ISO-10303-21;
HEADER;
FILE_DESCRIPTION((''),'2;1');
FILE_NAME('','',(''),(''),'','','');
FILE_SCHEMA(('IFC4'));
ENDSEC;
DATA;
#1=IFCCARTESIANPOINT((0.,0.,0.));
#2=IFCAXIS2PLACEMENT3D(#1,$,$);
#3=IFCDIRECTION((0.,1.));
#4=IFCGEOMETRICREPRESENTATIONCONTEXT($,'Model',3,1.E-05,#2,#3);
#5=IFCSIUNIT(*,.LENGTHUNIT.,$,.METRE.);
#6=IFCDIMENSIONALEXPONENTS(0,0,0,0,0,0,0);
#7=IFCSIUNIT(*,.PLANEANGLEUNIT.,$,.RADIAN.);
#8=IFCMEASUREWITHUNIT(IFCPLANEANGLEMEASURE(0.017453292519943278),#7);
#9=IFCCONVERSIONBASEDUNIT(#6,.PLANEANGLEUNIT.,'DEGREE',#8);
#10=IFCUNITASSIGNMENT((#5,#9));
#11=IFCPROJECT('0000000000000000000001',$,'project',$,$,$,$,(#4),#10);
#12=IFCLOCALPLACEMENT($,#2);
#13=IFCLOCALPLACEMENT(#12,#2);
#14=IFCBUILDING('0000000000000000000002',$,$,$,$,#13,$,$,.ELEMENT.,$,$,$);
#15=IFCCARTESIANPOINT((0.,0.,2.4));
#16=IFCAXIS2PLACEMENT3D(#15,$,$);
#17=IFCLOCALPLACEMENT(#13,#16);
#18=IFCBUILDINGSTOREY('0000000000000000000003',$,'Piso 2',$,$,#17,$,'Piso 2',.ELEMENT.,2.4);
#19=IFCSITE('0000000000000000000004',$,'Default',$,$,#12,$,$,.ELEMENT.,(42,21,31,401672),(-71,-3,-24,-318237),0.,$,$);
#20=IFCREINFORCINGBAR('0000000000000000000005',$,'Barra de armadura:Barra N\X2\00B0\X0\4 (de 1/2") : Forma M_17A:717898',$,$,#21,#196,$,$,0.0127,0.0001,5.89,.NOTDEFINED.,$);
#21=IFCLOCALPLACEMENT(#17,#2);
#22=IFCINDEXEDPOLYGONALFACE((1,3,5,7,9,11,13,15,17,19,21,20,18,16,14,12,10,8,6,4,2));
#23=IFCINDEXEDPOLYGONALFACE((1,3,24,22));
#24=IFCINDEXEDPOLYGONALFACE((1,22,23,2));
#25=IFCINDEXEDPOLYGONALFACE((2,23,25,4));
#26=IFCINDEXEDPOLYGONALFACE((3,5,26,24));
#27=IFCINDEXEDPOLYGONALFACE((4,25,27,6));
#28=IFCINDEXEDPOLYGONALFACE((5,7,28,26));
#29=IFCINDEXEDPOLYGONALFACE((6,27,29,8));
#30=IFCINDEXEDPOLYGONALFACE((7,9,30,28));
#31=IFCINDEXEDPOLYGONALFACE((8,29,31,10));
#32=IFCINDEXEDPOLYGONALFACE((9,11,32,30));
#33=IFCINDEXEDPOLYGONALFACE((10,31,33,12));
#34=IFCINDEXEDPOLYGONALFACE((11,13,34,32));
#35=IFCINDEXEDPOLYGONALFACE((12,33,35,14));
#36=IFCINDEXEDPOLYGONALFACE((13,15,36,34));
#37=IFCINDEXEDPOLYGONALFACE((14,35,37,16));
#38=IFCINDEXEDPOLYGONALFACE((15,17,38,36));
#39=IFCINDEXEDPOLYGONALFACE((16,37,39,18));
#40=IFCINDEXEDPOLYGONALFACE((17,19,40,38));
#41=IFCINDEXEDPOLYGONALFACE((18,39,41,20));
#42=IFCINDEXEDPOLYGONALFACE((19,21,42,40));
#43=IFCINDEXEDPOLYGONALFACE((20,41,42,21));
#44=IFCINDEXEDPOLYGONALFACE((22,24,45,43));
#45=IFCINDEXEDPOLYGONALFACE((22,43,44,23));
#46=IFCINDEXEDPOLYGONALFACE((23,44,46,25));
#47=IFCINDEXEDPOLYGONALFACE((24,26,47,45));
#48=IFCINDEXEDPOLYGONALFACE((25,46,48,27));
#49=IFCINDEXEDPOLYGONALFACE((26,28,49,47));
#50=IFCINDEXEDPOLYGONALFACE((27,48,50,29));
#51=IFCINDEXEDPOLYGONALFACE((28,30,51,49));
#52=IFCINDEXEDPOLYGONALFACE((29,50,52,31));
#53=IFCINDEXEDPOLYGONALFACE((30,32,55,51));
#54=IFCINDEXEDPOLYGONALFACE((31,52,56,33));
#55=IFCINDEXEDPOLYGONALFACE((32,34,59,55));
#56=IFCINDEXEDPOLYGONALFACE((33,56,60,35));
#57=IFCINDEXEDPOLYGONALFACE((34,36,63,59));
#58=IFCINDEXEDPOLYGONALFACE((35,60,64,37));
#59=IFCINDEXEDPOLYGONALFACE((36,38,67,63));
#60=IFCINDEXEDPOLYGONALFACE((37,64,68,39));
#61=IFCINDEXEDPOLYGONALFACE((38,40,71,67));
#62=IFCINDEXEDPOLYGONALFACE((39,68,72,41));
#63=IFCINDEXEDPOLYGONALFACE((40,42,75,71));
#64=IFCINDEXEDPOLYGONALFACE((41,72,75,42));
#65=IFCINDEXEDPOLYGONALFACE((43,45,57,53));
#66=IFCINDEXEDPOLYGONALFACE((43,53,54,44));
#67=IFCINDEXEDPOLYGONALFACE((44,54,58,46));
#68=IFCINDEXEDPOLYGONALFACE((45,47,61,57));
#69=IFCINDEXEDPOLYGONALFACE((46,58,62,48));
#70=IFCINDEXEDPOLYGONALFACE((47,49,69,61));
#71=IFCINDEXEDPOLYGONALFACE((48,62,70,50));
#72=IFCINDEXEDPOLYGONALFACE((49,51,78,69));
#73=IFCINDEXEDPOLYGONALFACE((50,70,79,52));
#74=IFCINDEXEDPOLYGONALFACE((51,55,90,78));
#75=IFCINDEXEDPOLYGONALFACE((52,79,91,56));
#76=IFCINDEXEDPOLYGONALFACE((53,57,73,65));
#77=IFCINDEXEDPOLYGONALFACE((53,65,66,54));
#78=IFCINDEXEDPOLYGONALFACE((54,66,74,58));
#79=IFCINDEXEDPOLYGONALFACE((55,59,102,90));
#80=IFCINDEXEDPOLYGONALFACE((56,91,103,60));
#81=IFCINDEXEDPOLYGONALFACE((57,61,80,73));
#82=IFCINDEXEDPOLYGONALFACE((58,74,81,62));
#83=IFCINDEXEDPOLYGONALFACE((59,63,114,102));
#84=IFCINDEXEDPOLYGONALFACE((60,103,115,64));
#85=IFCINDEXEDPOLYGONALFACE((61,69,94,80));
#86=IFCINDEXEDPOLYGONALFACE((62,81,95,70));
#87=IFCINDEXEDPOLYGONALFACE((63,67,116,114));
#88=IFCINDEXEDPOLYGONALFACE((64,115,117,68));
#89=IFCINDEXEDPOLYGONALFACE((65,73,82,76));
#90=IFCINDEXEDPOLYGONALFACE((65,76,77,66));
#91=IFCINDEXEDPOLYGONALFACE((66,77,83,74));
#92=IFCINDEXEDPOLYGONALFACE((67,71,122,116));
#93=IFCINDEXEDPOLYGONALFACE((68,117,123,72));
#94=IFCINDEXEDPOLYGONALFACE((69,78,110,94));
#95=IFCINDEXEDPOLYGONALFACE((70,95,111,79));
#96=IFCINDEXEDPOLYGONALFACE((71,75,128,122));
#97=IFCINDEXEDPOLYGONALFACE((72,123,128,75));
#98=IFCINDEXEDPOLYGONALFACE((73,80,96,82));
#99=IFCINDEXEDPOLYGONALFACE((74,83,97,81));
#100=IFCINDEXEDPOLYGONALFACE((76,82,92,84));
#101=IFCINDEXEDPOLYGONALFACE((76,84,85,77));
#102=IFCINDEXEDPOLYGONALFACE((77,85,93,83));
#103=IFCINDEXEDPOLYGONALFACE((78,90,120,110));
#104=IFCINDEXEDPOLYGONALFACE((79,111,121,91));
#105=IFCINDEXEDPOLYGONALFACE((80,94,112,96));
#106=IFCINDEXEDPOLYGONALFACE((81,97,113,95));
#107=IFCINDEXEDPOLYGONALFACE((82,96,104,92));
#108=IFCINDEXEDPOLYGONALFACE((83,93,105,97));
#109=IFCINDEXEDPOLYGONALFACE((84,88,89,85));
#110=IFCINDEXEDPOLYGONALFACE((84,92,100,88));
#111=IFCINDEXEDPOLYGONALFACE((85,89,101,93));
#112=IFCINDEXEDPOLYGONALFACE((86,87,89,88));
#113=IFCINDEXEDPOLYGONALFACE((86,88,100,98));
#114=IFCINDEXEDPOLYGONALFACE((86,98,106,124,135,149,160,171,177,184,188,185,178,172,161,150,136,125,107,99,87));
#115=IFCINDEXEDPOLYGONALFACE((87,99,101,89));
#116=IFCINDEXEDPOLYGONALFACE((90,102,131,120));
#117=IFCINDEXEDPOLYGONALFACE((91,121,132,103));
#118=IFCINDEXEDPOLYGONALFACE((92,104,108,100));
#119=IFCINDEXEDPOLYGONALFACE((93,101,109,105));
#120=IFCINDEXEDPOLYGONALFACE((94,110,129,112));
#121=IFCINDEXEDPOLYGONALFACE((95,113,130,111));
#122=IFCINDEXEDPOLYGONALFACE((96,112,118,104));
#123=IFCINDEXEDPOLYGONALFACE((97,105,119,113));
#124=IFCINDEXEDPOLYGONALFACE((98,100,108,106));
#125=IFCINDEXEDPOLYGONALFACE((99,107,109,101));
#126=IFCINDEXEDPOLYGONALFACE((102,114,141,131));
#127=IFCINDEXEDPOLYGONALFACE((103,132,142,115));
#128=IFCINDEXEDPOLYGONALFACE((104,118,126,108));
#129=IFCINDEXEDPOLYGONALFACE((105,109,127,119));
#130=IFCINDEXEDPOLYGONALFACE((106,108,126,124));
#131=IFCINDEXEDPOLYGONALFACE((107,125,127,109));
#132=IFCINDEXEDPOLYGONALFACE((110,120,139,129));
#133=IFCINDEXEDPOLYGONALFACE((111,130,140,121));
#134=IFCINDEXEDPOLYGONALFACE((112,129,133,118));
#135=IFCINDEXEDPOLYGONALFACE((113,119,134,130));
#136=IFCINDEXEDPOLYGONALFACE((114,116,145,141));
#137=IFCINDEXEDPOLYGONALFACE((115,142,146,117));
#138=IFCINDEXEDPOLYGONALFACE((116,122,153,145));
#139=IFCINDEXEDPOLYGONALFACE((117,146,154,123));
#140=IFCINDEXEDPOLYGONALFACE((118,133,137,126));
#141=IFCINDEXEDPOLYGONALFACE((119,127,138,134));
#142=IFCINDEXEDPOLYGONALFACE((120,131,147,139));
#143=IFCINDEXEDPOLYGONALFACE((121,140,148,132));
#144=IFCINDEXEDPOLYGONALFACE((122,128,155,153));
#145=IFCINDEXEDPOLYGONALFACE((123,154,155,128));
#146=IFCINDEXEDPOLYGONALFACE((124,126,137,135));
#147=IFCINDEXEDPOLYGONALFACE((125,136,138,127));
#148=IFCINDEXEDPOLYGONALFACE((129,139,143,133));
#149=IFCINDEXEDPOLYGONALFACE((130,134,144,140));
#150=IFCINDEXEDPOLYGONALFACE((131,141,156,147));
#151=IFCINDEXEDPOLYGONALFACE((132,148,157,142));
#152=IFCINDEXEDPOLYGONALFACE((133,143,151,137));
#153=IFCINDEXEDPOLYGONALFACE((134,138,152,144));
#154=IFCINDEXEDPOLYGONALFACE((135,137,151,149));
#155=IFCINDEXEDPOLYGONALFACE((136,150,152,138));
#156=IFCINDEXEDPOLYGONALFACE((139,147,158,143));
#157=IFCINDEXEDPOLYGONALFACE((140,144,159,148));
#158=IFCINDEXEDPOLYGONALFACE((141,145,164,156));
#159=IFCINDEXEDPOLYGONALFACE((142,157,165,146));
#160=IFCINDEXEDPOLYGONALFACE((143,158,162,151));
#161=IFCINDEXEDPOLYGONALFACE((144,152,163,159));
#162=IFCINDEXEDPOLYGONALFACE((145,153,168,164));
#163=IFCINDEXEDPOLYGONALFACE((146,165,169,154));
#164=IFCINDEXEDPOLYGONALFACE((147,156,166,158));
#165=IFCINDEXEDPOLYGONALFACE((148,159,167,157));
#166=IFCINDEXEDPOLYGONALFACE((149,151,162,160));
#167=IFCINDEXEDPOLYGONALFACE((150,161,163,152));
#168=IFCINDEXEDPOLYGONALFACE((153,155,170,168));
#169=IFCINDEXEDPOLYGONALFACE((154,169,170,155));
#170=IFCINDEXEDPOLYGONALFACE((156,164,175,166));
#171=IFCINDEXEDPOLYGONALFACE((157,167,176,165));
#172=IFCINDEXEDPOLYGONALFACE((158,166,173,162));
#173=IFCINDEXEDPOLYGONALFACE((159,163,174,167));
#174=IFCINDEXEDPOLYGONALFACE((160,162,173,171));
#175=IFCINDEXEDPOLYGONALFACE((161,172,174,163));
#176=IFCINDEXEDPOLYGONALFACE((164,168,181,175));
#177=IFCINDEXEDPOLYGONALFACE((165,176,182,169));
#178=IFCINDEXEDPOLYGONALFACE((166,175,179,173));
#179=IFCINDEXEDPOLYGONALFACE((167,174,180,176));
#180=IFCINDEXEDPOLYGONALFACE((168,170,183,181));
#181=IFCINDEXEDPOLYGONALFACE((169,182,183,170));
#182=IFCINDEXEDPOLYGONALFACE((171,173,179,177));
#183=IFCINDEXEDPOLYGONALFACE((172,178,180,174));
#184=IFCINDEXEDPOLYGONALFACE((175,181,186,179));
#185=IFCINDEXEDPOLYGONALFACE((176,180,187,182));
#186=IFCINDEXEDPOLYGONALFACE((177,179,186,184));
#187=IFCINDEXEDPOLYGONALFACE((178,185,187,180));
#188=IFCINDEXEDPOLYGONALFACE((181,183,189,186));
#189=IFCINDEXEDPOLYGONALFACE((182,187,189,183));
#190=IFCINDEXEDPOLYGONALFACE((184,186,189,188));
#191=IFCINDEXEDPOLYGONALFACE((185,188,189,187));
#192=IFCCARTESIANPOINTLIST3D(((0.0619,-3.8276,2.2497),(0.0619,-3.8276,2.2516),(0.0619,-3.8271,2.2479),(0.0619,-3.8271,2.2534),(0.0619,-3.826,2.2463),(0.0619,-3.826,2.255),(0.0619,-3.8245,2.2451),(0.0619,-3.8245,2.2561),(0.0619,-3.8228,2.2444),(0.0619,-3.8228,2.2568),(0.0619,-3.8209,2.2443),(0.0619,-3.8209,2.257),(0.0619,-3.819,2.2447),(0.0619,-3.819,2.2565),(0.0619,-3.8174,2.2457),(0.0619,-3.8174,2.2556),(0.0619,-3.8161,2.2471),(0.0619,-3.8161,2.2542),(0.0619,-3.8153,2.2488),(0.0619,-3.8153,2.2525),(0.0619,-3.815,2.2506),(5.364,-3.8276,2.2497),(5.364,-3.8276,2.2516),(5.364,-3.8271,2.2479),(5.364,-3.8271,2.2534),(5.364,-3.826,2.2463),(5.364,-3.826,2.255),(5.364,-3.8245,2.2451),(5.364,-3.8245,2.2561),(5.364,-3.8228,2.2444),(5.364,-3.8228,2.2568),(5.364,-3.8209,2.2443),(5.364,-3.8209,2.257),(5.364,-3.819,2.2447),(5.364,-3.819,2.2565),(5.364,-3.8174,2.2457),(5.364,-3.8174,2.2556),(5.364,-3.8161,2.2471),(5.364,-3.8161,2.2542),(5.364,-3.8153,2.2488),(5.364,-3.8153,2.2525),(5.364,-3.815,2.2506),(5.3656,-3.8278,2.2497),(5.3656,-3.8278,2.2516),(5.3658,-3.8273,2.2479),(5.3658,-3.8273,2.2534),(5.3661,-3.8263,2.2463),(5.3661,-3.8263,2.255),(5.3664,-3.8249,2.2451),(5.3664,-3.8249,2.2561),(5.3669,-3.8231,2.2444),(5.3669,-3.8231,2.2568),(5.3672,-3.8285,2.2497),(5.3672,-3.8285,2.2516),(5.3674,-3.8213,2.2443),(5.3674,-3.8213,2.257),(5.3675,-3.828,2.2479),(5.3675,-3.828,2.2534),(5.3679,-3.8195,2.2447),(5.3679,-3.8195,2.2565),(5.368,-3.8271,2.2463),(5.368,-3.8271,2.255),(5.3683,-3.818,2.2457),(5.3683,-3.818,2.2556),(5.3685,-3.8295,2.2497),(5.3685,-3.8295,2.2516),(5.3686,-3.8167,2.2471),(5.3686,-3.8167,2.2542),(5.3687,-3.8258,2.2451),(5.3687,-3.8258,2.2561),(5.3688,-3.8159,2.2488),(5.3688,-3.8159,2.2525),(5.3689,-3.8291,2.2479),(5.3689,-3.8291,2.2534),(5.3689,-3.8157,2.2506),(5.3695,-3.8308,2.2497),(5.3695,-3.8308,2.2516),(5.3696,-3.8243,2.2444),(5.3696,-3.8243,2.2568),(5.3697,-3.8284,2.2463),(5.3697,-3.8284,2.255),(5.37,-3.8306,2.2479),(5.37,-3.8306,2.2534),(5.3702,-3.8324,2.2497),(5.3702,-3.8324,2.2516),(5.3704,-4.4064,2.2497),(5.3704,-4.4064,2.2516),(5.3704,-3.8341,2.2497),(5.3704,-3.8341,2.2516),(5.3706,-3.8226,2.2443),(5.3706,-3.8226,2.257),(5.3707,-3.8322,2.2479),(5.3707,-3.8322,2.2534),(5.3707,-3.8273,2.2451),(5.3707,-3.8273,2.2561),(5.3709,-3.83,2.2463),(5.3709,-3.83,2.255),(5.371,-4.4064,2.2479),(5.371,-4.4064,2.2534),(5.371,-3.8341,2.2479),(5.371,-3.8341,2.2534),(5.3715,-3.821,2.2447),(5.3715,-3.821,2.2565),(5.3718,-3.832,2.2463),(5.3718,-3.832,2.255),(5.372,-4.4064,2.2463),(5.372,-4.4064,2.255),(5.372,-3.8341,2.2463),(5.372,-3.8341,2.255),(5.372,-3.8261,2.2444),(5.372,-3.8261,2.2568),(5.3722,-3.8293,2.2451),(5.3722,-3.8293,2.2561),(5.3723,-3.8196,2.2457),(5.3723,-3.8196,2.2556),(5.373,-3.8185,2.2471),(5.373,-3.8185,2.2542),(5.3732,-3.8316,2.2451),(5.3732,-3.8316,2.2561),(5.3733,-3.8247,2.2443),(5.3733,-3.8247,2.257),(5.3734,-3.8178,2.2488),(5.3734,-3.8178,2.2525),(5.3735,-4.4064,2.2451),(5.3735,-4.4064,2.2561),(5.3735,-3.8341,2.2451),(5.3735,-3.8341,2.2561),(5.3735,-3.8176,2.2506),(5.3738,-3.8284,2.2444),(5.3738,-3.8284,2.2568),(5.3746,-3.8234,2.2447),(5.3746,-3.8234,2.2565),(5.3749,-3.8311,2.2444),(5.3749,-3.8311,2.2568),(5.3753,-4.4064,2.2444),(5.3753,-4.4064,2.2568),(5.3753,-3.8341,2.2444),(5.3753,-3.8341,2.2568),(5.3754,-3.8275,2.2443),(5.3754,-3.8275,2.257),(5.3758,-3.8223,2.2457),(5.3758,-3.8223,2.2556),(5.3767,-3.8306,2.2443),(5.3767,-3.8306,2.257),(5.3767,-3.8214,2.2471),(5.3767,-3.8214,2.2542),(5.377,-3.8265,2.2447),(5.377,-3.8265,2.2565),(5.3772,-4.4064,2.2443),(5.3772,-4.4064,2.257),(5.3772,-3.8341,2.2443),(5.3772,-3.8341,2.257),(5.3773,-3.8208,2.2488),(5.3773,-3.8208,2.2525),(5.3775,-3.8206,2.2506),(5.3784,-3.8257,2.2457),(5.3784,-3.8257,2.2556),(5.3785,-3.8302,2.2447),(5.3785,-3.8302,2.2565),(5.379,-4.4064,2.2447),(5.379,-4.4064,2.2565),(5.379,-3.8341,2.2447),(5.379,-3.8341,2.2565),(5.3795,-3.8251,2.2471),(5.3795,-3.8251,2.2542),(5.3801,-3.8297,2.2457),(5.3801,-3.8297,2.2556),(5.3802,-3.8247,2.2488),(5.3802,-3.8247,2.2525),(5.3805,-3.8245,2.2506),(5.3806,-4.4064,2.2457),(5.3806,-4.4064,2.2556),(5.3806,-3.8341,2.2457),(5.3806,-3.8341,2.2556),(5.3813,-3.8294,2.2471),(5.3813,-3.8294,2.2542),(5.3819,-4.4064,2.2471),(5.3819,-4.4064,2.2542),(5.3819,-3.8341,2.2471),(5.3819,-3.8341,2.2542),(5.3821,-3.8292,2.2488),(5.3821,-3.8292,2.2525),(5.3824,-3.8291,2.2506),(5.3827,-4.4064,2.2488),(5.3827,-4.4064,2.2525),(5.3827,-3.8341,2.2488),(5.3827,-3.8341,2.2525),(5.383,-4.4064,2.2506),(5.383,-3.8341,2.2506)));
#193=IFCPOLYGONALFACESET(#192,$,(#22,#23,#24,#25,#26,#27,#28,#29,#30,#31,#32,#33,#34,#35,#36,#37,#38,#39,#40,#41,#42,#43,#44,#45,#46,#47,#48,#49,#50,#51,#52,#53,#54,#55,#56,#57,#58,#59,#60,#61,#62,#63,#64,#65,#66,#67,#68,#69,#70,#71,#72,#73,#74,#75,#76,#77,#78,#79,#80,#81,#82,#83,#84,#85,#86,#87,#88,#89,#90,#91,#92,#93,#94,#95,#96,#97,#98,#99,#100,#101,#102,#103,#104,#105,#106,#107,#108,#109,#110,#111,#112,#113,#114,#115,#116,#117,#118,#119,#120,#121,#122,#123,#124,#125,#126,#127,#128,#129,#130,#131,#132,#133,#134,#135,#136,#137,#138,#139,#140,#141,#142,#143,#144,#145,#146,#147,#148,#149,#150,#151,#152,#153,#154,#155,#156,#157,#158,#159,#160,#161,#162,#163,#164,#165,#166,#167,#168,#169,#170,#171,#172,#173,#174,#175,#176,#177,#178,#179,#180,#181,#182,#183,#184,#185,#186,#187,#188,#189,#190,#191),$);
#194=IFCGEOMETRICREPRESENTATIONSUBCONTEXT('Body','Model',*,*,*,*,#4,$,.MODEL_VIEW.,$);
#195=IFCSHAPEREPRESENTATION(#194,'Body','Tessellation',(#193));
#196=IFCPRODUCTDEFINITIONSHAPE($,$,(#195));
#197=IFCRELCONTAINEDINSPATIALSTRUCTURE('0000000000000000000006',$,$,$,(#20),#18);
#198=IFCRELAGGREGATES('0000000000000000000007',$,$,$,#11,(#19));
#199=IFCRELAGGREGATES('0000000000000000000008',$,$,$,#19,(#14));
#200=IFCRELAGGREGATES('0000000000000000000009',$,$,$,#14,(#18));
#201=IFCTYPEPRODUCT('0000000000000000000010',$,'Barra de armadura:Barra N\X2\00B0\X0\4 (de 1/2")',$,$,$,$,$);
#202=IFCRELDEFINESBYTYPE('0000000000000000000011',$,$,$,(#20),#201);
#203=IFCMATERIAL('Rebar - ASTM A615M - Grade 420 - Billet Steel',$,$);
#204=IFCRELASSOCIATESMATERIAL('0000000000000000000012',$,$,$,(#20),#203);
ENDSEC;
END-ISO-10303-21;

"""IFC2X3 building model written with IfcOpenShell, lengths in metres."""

from ifc_helpers import new_model, entity, si_unit, converted_unit, direction, frame, origin, place, context, subcontext, project, spatial, material, type_object, element, save


model = new_model("IFC2X3")

# Units and contexts
model_context = context("Model", 3, precision=1e-05, world=origin(), true_north=direction((0.0, 1.0)))
body_context = subcontext(model_context, "Body", "Model", "MODEL_VIEW")
ifc_project = project(units=[si_unit("LENGTHUNIT", "METRE"), converted_unit("PLANEANGLEUNIT", "DEGREE", entity("IfcPlaneAngleMeasure", 0.017453292519943278), si_unit("PLANEANGLEUNIT", "RADIAN"), dimensions=[0, 0, 0, 0, 0, 0, 0])], contexts=[model_context])

# Site, building, storey
site_placement = place(None, origin())
site = spatial("IfcSite", under=ifc_project, at=site_placement, Name="Default", CompositionType="ELEMENT", RefLatitude=(42, 21, 31, 401672), RefLongitude=(-71, -3, -24, -318237), RefElevation=0.0)
building_placement = place(site_placement, origin())
building = spatial("IfcBuilding", under=site, at=building_placement, CompositionType="ELEMENT")
storey_placement = place(building_placement, frame((0.0, 0.0, 2.4)))
storey = spatial("IfcBuildingStorey", under=building, at=storey_placement, Name="Piso 2", LongName="Piso 2", CompositionType="ELEMENT", Elevation=2.4)

# Reinforcing bar
ifc_material_1 = material(Name="Rebar - ASTM A615M - Grade 420 - Billet Steel")
type_product_1 = type_object("IfcTypeProduct", Name="Barra de armadura:Barra N°4 (de 1/2\")")
reinforcing_bar_1_placement = place(storey_placement, origin())
element("IfcReinforcingBar", 1, at=reinforcing_bar_1_placement, inside=storey, type_object=type_product_1, material=ifc_material_1, Name="Barra de armadura:Barra N°4 (de 1/2\") : Forma M_17A:717898", BarLength=5.89, BarRole="NOTDEFINED", CrossSectionArea=0.0001, NominalDiameter=0.0127, context=body_context, shape_type="AdvancedSweptSolid", body=[
    entity("IfcSweptDiskSolid", entity("IfcCompositeCurve", [entity("IfcCompositeCurveSegment", "CONTINUOUS", True, entity("IfcPolyline", [entity("IfcCartesianPoint", [0.0619, -3.8214, 2.2506]), entity("IfcCartesianPoint", [5.364, -3.8214, 2.2506])])), entity("IfcCompositeCurveSegment", "CONTINUOUS", True, entity("IfcTrimmedCurve", entity("IfcCircle", entity("IfcAxis2Placement3D", entity("IfcCartesianPoint", [5.364, -3.8341, 2.2506]), entity("IfcDirection", [0.0, 0.0, -1.0]), entity("IfcDirection", [1.0, 0.0, 0.0])), 0.0127), [entity("IfcParameterValue", 270.0)], [entity("IfcParameterValue", 360.0)], True, "PARAMETER")), entity("IfcCompositeCurveSegment", "CONTINUOUS", True, entity("IfcPolyline", [entity("IfcCartesianPoint", [5.3767, -3.8341, 2.2506]), entity("IfcCartesianPoint", [5.3767, -4.4064, 2.2506])]))], False), 0.0063, None, 0.0, 92.0),
])

save(model, "model.ifc")
